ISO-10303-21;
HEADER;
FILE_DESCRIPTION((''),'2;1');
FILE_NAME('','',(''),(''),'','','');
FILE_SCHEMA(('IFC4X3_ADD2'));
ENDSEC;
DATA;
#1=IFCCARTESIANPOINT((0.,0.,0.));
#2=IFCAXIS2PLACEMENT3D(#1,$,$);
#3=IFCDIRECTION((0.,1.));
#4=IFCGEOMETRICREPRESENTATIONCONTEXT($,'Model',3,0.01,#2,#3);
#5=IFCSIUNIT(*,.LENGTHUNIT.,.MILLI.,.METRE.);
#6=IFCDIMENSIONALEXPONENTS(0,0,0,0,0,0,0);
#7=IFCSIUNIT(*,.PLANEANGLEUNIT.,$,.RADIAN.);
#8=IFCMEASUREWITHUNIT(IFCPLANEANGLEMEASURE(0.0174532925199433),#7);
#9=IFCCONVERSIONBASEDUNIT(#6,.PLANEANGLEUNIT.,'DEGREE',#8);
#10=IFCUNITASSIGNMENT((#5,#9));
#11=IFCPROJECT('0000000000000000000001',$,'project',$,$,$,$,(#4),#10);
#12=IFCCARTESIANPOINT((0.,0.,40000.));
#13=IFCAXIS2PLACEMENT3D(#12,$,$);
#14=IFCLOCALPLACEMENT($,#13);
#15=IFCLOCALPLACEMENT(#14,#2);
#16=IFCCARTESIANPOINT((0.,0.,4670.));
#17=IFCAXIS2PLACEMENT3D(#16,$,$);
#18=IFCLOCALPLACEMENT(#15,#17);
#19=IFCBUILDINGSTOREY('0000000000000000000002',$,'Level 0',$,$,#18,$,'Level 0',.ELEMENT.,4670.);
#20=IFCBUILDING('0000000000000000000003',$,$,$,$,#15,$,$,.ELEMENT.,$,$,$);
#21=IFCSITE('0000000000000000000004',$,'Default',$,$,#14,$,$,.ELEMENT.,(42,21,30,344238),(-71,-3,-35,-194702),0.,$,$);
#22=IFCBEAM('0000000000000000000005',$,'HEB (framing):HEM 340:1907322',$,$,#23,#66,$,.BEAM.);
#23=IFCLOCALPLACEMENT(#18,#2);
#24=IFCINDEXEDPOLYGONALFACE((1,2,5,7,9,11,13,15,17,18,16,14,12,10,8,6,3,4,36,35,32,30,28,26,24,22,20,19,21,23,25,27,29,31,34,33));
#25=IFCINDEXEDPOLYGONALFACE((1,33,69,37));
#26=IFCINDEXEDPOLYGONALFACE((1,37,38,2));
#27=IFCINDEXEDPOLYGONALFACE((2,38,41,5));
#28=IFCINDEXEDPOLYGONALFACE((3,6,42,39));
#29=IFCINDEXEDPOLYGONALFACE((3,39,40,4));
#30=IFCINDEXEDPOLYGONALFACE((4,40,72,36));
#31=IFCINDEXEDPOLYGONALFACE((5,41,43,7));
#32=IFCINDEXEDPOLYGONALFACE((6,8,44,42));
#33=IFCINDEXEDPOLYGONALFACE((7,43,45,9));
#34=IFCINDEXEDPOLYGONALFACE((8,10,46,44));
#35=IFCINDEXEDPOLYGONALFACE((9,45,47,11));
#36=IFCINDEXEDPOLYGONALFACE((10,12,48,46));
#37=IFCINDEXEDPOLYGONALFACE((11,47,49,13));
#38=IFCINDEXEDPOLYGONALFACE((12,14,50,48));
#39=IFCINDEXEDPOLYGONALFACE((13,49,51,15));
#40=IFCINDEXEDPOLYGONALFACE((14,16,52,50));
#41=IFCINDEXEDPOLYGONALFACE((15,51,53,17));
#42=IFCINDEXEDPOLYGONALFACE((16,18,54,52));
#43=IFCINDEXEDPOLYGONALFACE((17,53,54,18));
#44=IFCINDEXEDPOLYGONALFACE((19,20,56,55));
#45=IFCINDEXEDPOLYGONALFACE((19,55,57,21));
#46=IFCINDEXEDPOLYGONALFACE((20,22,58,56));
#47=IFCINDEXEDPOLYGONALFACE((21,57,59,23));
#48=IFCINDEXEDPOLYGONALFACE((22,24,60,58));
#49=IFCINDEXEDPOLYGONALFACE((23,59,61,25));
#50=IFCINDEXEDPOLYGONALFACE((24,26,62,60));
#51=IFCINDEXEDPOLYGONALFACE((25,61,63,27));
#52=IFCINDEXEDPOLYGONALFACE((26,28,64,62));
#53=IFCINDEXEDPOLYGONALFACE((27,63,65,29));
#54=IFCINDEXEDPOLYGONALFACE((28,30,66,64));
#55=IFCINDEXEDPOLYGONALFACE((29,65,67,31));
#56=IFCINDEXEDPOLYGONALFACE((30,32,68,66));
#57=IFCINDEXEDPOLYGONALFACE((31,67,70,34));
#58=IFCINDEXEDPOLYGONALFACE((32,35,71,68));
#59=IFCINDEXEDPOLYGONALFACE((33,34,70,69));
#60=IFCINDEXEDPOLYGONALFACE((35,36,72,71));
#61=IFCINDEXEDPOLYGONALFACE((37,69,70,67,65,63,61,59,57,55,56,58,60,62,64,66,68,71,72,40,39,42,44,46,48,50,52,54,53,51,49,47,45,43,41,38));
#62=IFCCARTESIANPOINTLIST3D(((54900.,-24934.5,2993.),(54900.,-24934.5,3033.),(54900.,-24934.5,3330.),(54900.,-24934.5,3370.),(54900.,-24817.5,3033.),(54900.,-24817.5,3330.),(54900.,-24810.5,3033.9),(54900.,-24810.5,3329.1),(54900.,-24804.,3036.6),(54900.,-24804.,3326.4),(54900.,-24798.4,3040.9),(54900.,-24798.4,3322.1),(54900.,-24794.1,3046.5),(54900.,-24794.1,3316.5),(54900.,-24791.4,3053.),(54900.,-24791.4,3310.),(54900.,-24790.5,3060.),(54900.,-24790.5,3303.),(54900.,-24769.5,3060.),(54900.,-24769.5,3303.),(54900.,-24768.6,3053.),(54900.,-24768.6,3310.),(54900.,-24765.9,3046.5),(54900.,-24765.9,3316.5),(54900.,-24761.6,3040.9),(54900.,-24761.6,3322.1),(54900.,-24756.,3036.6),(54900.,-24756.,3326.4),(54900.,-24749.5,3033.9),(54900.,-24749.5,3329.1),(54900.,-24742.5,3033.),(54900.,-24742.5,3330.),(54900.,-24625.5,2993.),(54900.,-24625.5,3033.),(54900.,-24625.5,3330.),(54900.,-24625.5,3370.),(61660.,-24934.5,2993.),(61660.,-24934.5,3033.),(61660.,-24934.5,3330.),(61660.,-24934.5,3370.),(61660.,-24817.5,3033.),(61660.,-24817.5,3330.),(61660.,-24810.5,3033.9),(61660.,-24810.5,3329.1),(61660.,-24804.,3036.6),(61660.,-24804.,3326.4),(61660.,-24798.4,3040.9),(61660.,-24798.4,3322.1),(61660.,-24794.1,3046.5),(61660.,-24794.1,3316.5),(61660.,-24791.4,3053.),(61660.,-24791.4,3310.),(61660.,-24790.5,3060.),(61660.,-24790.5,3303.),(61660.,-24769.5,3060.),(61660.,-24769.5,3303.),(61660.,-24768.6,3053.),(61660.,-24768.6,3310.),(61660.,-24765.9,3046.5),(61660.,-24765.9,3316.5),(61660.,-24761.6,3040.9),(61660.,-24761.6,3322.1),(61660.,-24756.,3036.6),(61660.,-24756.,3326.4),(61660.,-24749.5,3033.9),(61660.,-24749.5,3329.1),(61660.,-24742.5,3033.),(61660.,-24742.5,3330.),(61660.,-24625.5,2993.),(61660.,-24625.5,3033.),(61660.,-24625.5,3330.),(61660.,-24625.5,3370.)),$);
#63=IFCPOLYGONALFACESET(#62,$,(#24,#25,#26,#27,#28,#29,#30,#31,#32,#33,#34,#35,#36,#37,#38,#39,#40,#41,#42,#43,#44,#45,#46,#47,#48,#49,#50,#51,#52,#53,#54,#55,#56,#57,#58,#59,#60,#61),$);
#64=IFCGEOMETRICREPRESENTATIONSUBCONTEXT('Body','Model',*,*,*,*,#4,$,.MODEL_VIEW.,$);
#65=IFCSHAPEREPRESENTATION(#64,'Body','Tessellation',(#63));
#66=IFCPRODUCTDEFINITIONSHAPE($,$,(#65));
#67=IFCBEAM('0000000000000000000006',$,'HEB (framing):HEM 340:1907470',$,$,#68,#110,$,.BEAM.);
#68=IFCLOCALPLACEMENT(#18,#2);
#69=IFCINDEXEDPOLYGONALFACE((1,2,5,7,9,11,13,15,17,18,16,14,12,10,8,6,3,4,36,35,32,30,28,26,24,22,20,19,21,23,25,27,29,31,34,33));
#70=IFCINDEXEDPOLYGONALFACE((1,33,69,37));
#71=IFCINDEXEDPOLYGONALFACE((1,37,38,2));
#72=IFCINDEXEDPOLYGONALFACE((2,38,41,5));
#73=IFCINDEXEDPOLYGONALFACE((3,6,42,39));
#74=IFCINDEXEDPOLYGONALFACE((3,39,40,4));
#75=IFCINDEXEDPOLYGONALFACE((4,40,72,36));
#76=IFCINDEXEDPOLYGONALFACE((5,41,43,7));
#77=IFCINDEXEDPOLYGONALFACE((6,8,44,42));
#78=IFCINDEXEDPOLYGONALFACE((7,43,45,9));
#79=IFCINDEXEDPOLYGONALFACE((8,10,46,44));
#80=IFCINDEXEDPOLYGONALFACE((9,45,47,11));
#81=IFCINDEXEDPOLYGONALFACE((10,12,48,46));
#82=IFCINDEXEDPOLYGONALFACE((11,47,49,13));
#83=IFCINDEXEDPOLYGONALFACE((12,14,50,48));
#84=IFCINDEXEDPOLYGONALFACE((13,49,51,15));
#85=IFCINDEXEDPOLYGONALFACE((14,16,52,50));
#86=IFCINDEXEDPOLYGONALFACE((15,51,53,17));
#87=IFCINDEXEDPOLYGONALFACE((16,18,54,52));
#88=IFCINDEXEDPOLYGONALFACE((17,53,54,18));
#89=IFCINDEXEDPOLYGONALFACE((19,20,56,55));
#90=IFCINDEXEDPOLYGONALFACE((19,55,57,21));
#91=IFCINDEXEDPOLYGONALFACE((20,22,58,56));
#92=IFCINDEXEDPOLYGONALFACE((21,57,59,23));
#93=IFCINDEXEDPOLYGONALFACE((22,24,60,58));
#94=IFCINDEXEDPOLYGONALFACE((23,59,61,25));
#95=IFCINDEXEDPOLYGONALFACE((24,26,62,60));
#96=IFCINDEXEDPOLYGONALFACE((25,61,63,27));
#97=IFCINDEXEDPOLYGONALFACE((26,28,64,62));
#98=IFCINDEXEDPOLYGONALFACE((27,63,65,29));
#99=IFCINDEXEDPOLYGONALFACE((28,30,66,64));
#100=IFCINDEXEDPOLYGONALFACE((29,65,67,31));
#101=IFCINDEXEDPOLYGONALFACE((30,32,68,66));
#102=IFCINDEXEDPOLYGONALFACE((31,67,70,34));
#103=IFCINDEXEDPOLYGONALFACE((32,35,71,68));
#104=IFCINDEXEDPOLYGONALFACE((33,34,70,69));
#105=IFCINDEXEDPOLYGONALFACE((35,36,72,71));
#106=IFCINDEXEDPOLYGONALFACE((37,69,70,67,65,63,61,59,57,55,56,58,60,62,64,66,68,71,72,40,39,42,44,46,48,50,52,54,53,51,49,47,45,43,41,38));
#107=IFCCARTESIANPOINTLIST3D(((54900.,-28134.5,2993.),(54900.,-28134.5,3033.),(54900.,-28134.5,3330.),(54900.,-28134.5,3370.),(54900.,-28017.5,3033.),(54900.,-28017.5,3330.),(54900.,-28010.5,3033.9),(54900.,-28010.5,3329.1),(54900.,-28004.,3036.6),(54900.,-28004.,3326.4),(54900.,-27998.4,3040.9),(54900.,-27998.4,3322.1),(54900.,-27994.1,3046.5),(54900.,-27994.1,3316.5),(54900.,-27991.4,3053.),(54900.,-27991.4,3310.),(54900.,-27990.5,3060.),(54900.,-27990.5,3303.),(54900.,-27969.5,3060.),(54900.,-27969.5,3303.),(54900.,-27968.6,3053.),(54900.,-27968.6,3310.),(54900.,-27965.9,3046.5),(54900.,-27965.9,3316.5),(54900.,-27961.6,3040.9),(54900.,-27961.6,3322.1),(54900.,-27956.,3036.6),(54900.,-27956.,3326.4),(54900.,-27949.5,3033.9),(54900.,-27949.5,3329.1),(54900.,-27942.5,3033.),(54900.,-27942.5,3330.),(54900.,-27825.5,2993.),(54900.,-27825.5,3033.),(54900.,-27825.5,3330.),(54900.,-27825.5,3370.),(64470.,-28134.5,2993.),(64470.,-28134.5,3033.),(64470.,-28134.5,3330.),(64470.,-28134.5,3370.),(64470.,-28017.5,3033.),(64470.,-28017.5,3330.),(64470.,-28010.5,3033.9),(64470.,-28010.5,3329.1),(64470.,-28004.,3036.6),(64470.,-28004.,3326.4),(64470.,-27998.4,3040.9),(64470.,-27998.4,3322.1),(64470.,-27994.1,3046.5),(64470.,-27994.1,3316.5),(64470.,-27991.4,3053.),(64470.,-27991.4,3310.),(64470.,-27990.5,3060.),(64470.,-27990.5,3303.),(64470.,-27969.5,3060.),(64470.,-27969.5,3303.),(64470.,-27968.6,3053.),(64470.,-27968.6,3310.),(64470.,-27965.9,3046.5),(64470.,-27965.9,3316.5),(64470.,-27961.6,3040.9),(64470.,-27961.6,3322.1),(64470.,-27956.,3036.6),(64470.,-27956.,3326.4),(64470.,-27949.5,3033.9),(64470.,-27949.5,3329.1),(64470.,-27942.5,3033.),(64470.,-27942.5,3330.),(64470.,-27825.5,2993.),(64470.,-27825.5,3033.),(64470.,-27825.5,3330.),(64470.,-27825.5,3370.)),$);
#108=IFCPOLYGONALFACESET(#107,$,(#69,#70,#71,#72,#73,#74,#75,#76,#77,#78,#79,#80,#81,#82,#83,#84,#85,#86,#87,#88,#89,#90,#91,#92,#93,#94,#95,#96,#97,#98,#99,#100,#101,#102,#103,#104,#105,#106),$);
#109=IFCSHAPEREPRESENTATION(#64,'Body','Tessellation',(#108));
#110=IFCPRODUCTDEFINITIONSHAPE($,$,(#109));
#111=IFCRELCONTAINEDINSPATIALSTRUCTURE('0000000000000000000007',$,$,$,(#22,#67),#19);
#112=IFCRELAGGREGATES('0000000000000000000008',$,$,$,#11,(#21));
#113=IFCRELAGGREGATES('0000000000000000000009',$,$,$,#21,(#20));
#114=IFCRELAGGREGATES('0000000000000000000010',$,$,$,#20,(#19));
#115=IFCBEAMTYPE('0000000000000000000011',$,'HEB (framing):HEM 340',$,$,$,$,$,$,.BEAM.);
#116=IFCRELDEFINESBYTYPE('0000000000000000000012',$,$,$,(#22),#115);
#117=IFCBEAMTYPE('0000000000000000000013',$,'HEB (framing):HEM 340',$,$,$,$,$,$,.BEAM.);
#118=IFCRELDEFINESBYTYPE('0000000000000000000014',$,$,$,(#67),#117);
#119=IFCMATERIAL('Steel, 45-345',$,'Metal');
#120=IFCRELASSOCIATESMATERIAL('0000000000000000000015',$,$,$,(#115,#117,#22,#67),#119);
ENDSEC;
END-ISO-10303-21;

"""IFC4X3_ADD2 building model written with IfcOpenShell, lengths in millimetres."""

from ifc_helpers import new_model, entity, si_unit, converted_unit, direction, frame, frame_2d, origin, place, context, subcontext, project, spatial, polyline, circle_curve, parameter, trimmed, segment, composite_curve, outline, extrude, source, transform, mapped, material, material_profile, profile_set, profile_usage, type_object, type_shapes, element, save


model = new_model("IFC4X3_ADD2")

# Units and contexts
model_context = context("Model", 3, precision=0.01, world=origin(), true_north=direction((0.0, 1.0)))
body_context = subcontext(model_context, "Body", "Model", "MODEL_VIEW")
ifc_project = project(units=[si_unit("LENGTHUNIT", "METRE", prefix="MILLI"), converted_unit("PLANEANGLEUNIT", "DEGREE", entity("IfcPlaneAngleMeasure", 0.0174532925199433), si_unit("PLANEANGLEUNIT", "RADIAN"), dimensions=[0, 0, 0, 0, 0, 0, 0])], contexts=[model_context])

# Site, building, storey
site_placement = place(None, frame((0.0, 0.0, 40000.0)))
site = spatial("IfcSite", under=ifc_project, at=site_placement, Name="Default", CompositionType="ELEMENT", RefLatitude=(42, 21, 30, 344238), RefLongitude=(-71, -3, -35, -194702), RefElevation=0.0)
building_placement = place(site_placement, origin())
building = spatial("IfcBuilding", under=site, at=building_placement, CompositionType="ELEMENT")
storey_placement = place(building_placement, frame((0.0, 0.0, 4670.0)))
storey = spatial("IfcBuildingStorey", under=building, at=storey_placement, Name="Level 0", LongName="Level 0", CompositionType="ELEMENT", Elevation=4670.0)

# Shared definitions
ifc_material_1 = material(Name="Steel, 45-345", Category="Metal")

# Beams
ifc_material_profile_1 = material_profile(ifc_material_1, outline(composite_curve([segment(polyline([(-154.5, -148.5), (-154.5, -188.5)]), True, "CONTINUOUS"), segment(polyline([(-154.5, -188.5), (154.5, -188.5)]), True, "CONTINUOUS"), segment(polyline([(154.5, -188.5), (154.5, -148.5)]), True, "CONTINUOUS"), segment(polyline([(154.5, -148.5), (37.5, -148.5)]), True, "CONTINUOUS"), segment(trimmed(circle_curve(frame_2d((37.5, -121.5), x_axis=(1.0, 0.0)), 27.0), [parameter(180.0)], [parameter(270.0)], True, "PARAMETER"), False, "CONTINUOUS"), segment(polyline([(10.5, -121.5), (10.5, 121.5)]), True, "CONTINUOUS"), segment(trimmed(circle_curve(frame_2d((37.5, 121.5), x_axis=(1.0, 0.0)), 27.0), [parameter(90.0)], [parameter(180.0)], True, "PARAMETER"), False, "CONTINUOUS"), segment(polyline([(37.5, 148.5), (154.5, 148.5)]), True, "CONTINUOUS"), segment(polyline([(154.5, 148.5), (154.5, 188.5)]), True, "CONTINUOUS"), segment(polyline([(154.5, 188.5), (-154.5, 188.5)]), True, "CONTINUOUS"), segment(polyline([(-154.5, 188.5), (-154.5, 148.5)]), True, "CONTINUOUS"), segment(polyline([(-154.5, 148.5), (-37.5, 148.5)]), True, "CONTINUOUS"), segment(trimmed(circle_curve(frame_2d((-37.5, 121.5), x_axis=(1.0, 0.0)), 27.0), [parameter(360.0)], [parameter(90.0)], True, "PARAMETER"), False, "CONTINUOUS"), segment(polyline([(-10.5, 121.5), (-10.5, -121.5)]), True, "CONTINUOUS"), segment(trimmed(circle_curve(frame_2d((-37.5, -121.5), x_axis=(1.0, 0.0)), 27.0), [parameter(270.0)], [parameter(0.0)], True, "PARAMETER"), False, "CONTINUOUS"), segment(polyline([(-37.5, -148.5), (-154.5, -148.5)]), True, "CONTINUOUS")], self_intersect=False)), Name="HEM 340")
ifc_profile_set_1 = profile_set([ifc_material_profile_1], Name="HEM 340")
ifc_profile_usage_1 = profile_usage(ifc_profile_set_1, cardinal=8)
beam_type_1 = type_object("IfcBeamType", Name="HEB (framing):HEM 340", PredefinedType="BEAM", material=ifc_profile_set_1)
shared_shape_1 = source(origin(), body_context, "Body", "SweptSolid", [
    extrude(outline(composite_curve([segment(polyline([(-154.5, -148.5), (-154.5, -188.5)]), True, "CONTINUOUS"), segment(polyline([(-154.5, -188.5), (154.5, -188.5)]), True, "CONTINUOUS"), segment(polyline([(154.5, -188.5), (154.5, -148.5)]), True, "CONTINUOUS"), segment(polyline([(154.5, -148.5), (37.5, -148.5)]), True, "CONTINUOUS"), segment(trimmed(circle_curve(frame_2d((37.5, -121.5), x_axis=(1.0, 0.0)), 27.0), [parameter(180.0)], [parameter(270.0)], True, "PARAMETER"), False, "CONTINUOUS"), segment(polyline([(10.5, -121.5), (10.5, 121.5)]), True, "CONTINUOUS"), segment(trimmed(circle_curve(frame_2d((37.5, 121.5), x_axis=(1.0, 0.0)), 27.0), [parameter(90.0)], [parameter(180.0)], True, "PARAMETER"), False, "CONTINUOUS"), segment(polyline([(37.5, 148.5), (154.5, 148.5)]), True, "CONTINUOUS"), segment(polyline([(154.5, 148.5), (154.5, 188.5)]), True, "CONTINUOUS"), segment(polyline([(154.5, 188.5), (-154.5, 188.5)]), True, "CONTINUOUS"), segment(polyline([(-154.5, 188.5), (-154.5, 148.5)]), True, "CONTINUOUS"), segment(polyline([(-154.5, 148.5), (-37.5, 148.5)]), True, "CONTINUOUS"), segment(trimmed(circle_curve(frame_2d((-37.5, 121.5), x_axis=(1.0, 0.0)), 27.0), [parameter(360.0)], [parameter(90.0)], True, "PARAMETER"), False, "CONTINUOUS"), segment(polyline([(-10.5, 121.5), (-10.5, -121.5)]), True, "CONTINUOUS"), segment(trimmed(circle_curve(frame_2d((-37.5, -121.5), x_axis=(1.0, 0.0)), 27.0), [parameter(270.0)], [parameter(0.0)], True, "PARAMETER"), False, "CONTINUOUS"), segment(polyline([(-37.5, -148.5), (-154.5, -148.5)]), True, "CONTINUOUS")], self_intersect=False)), frame((-3397.7, 0.0, 0.0), z_axis=(-1.0, 0.0, 0.0), x_axis=(0.0, -1.0, 0.0)), (0.0, 0.0, -1.0), 6760.0),
])
type_shapes(beam_type_1, [shared_shape_1])
beam_1_placement = place(storey_placement, frame((58297.7, -24780.0, 3181.5)))
element("IfcBeam", 1, at=beam_1_placement, inside=storey, type_object=beam_type_1, material=ifc_profile_usage_1, Name="HEB (framing):HEM 340:1907322", PredefinedType="BEAM", context=body_context, shape_type="MappedRepresentation", body=[
    mapped(shared_shape_1, transform((0.0, 0.0, 0.0), scale=1.0)),
])
beam_type_2 = type_object("IfcBeamType", Name="HEB (framing):HEM 340", PredefinedType="BEAM", material=ifc_profile_set_1)
shared_shape_2 = source(origin(), body_context, "Body", "SweptSolid", [
    extrude(outline(composite_curve([segment(polyline([(-154.5, -148.5), (-154.5, -188.5)]), True, "CONTINUOUS"), segment(polyline([(-154.5, -188.5), (154.5, -188.5)]), True, "CONTINUOUS"), segment(polyline([(154.5, -188.5), (154.5, -148.5)]), True, "CONTINUOUS"), segment(polyline([(154.5, -148.5), (37.5, -148.5)]), True, "CONTINUOUS"), segment(trimmed(circle_curve(frame_2d((37.5, -121.5), x_axis=(1.0, 0.0)), 27.0), [parameter(180.0)], [parameter(270.0)], True, "PARAMETER"), False, "CONTINUOUS"), segment(polyline([(10.5, -121.5), (10.5, 121.5)]), True, "CONTINUOUS"), segment(trimmed(circle_curve(frame_2d((37.5, 121.5), x_axis=(1.0, 0.0)), 27.0), [parameter(90.0)], [parameter(180.0)], True, "PARAMETER"), False, "CONTINUOUS"), segment(polyline([(37.5, 148.5), (154.5, 148.5)]), True, "CONTINUOUS"), segment(polyline([(154.5, 148.5), (154.5, 188.5)]), True, "CONTINUOUS"), segment(polyline([(154.5, 188.5), (-154.5, 188.5)]), True, "CONTINUOUS"), segment(polyline([(-154.5, 188.5), (-154.5, 148.5)]), True, "CONTINUOUS"), segment(polyline([(-154.5, 148.5), (-37.5, 148.5)]), True, "CONTINUOUS"), segment(trimmed(circle_curve(frame_2d((-37.5, 121.5), x_axis=(1.0, 0.0)), 27.0), [parameter(360.0)], [parameter(90.0)], True, "PARAMETER"), False, "CONTINUOUS"), segment(polyline([(-10.5, 121.5), (-10.5, -121.5)]), True, "CONTINUOUS"), segment(trimmed(circle_curve(frame_2d((-37.5, -121.5), x_axis=(1.0, 0.0)), 27.0), [parameter(270.0)], [parameter(0.0)], True, "PARAMETER"), False, "CONTINUOUS"), segment(polyline([(-37.5, -148.5), (-154.5, -148.5)]), True, "CONTINUOUS")], self_intersect=False)), frame((-4685.0, 0.0, 0.0), z_axis=(-1.0, 0.0, 0.0), x_axis=(0.0, -1.0, 0.0)), (0.0, 0.0, -1.0), 9570.0),
])
type_shapes(beam_type_2, [shared_shape_2])
beam_2_placement = place(storey_placement, frame((59585.0, -27980.0, 3181.5)))
element("IfcBeam", 2, at=beam_2_placement, inside=storey, type_object=beam_type_2, material=ifc_profile_usage_1, Name="HEB (framing):HEM 340:1907470", PredefinedType="BEAM", context=body_context, shape_type="MappedRepresentation", body=[
    mapped(shared_shape_2, transform((0.0, 0.0, 0.0), scale=1.0)),
])

save(model, "model.ifc")
